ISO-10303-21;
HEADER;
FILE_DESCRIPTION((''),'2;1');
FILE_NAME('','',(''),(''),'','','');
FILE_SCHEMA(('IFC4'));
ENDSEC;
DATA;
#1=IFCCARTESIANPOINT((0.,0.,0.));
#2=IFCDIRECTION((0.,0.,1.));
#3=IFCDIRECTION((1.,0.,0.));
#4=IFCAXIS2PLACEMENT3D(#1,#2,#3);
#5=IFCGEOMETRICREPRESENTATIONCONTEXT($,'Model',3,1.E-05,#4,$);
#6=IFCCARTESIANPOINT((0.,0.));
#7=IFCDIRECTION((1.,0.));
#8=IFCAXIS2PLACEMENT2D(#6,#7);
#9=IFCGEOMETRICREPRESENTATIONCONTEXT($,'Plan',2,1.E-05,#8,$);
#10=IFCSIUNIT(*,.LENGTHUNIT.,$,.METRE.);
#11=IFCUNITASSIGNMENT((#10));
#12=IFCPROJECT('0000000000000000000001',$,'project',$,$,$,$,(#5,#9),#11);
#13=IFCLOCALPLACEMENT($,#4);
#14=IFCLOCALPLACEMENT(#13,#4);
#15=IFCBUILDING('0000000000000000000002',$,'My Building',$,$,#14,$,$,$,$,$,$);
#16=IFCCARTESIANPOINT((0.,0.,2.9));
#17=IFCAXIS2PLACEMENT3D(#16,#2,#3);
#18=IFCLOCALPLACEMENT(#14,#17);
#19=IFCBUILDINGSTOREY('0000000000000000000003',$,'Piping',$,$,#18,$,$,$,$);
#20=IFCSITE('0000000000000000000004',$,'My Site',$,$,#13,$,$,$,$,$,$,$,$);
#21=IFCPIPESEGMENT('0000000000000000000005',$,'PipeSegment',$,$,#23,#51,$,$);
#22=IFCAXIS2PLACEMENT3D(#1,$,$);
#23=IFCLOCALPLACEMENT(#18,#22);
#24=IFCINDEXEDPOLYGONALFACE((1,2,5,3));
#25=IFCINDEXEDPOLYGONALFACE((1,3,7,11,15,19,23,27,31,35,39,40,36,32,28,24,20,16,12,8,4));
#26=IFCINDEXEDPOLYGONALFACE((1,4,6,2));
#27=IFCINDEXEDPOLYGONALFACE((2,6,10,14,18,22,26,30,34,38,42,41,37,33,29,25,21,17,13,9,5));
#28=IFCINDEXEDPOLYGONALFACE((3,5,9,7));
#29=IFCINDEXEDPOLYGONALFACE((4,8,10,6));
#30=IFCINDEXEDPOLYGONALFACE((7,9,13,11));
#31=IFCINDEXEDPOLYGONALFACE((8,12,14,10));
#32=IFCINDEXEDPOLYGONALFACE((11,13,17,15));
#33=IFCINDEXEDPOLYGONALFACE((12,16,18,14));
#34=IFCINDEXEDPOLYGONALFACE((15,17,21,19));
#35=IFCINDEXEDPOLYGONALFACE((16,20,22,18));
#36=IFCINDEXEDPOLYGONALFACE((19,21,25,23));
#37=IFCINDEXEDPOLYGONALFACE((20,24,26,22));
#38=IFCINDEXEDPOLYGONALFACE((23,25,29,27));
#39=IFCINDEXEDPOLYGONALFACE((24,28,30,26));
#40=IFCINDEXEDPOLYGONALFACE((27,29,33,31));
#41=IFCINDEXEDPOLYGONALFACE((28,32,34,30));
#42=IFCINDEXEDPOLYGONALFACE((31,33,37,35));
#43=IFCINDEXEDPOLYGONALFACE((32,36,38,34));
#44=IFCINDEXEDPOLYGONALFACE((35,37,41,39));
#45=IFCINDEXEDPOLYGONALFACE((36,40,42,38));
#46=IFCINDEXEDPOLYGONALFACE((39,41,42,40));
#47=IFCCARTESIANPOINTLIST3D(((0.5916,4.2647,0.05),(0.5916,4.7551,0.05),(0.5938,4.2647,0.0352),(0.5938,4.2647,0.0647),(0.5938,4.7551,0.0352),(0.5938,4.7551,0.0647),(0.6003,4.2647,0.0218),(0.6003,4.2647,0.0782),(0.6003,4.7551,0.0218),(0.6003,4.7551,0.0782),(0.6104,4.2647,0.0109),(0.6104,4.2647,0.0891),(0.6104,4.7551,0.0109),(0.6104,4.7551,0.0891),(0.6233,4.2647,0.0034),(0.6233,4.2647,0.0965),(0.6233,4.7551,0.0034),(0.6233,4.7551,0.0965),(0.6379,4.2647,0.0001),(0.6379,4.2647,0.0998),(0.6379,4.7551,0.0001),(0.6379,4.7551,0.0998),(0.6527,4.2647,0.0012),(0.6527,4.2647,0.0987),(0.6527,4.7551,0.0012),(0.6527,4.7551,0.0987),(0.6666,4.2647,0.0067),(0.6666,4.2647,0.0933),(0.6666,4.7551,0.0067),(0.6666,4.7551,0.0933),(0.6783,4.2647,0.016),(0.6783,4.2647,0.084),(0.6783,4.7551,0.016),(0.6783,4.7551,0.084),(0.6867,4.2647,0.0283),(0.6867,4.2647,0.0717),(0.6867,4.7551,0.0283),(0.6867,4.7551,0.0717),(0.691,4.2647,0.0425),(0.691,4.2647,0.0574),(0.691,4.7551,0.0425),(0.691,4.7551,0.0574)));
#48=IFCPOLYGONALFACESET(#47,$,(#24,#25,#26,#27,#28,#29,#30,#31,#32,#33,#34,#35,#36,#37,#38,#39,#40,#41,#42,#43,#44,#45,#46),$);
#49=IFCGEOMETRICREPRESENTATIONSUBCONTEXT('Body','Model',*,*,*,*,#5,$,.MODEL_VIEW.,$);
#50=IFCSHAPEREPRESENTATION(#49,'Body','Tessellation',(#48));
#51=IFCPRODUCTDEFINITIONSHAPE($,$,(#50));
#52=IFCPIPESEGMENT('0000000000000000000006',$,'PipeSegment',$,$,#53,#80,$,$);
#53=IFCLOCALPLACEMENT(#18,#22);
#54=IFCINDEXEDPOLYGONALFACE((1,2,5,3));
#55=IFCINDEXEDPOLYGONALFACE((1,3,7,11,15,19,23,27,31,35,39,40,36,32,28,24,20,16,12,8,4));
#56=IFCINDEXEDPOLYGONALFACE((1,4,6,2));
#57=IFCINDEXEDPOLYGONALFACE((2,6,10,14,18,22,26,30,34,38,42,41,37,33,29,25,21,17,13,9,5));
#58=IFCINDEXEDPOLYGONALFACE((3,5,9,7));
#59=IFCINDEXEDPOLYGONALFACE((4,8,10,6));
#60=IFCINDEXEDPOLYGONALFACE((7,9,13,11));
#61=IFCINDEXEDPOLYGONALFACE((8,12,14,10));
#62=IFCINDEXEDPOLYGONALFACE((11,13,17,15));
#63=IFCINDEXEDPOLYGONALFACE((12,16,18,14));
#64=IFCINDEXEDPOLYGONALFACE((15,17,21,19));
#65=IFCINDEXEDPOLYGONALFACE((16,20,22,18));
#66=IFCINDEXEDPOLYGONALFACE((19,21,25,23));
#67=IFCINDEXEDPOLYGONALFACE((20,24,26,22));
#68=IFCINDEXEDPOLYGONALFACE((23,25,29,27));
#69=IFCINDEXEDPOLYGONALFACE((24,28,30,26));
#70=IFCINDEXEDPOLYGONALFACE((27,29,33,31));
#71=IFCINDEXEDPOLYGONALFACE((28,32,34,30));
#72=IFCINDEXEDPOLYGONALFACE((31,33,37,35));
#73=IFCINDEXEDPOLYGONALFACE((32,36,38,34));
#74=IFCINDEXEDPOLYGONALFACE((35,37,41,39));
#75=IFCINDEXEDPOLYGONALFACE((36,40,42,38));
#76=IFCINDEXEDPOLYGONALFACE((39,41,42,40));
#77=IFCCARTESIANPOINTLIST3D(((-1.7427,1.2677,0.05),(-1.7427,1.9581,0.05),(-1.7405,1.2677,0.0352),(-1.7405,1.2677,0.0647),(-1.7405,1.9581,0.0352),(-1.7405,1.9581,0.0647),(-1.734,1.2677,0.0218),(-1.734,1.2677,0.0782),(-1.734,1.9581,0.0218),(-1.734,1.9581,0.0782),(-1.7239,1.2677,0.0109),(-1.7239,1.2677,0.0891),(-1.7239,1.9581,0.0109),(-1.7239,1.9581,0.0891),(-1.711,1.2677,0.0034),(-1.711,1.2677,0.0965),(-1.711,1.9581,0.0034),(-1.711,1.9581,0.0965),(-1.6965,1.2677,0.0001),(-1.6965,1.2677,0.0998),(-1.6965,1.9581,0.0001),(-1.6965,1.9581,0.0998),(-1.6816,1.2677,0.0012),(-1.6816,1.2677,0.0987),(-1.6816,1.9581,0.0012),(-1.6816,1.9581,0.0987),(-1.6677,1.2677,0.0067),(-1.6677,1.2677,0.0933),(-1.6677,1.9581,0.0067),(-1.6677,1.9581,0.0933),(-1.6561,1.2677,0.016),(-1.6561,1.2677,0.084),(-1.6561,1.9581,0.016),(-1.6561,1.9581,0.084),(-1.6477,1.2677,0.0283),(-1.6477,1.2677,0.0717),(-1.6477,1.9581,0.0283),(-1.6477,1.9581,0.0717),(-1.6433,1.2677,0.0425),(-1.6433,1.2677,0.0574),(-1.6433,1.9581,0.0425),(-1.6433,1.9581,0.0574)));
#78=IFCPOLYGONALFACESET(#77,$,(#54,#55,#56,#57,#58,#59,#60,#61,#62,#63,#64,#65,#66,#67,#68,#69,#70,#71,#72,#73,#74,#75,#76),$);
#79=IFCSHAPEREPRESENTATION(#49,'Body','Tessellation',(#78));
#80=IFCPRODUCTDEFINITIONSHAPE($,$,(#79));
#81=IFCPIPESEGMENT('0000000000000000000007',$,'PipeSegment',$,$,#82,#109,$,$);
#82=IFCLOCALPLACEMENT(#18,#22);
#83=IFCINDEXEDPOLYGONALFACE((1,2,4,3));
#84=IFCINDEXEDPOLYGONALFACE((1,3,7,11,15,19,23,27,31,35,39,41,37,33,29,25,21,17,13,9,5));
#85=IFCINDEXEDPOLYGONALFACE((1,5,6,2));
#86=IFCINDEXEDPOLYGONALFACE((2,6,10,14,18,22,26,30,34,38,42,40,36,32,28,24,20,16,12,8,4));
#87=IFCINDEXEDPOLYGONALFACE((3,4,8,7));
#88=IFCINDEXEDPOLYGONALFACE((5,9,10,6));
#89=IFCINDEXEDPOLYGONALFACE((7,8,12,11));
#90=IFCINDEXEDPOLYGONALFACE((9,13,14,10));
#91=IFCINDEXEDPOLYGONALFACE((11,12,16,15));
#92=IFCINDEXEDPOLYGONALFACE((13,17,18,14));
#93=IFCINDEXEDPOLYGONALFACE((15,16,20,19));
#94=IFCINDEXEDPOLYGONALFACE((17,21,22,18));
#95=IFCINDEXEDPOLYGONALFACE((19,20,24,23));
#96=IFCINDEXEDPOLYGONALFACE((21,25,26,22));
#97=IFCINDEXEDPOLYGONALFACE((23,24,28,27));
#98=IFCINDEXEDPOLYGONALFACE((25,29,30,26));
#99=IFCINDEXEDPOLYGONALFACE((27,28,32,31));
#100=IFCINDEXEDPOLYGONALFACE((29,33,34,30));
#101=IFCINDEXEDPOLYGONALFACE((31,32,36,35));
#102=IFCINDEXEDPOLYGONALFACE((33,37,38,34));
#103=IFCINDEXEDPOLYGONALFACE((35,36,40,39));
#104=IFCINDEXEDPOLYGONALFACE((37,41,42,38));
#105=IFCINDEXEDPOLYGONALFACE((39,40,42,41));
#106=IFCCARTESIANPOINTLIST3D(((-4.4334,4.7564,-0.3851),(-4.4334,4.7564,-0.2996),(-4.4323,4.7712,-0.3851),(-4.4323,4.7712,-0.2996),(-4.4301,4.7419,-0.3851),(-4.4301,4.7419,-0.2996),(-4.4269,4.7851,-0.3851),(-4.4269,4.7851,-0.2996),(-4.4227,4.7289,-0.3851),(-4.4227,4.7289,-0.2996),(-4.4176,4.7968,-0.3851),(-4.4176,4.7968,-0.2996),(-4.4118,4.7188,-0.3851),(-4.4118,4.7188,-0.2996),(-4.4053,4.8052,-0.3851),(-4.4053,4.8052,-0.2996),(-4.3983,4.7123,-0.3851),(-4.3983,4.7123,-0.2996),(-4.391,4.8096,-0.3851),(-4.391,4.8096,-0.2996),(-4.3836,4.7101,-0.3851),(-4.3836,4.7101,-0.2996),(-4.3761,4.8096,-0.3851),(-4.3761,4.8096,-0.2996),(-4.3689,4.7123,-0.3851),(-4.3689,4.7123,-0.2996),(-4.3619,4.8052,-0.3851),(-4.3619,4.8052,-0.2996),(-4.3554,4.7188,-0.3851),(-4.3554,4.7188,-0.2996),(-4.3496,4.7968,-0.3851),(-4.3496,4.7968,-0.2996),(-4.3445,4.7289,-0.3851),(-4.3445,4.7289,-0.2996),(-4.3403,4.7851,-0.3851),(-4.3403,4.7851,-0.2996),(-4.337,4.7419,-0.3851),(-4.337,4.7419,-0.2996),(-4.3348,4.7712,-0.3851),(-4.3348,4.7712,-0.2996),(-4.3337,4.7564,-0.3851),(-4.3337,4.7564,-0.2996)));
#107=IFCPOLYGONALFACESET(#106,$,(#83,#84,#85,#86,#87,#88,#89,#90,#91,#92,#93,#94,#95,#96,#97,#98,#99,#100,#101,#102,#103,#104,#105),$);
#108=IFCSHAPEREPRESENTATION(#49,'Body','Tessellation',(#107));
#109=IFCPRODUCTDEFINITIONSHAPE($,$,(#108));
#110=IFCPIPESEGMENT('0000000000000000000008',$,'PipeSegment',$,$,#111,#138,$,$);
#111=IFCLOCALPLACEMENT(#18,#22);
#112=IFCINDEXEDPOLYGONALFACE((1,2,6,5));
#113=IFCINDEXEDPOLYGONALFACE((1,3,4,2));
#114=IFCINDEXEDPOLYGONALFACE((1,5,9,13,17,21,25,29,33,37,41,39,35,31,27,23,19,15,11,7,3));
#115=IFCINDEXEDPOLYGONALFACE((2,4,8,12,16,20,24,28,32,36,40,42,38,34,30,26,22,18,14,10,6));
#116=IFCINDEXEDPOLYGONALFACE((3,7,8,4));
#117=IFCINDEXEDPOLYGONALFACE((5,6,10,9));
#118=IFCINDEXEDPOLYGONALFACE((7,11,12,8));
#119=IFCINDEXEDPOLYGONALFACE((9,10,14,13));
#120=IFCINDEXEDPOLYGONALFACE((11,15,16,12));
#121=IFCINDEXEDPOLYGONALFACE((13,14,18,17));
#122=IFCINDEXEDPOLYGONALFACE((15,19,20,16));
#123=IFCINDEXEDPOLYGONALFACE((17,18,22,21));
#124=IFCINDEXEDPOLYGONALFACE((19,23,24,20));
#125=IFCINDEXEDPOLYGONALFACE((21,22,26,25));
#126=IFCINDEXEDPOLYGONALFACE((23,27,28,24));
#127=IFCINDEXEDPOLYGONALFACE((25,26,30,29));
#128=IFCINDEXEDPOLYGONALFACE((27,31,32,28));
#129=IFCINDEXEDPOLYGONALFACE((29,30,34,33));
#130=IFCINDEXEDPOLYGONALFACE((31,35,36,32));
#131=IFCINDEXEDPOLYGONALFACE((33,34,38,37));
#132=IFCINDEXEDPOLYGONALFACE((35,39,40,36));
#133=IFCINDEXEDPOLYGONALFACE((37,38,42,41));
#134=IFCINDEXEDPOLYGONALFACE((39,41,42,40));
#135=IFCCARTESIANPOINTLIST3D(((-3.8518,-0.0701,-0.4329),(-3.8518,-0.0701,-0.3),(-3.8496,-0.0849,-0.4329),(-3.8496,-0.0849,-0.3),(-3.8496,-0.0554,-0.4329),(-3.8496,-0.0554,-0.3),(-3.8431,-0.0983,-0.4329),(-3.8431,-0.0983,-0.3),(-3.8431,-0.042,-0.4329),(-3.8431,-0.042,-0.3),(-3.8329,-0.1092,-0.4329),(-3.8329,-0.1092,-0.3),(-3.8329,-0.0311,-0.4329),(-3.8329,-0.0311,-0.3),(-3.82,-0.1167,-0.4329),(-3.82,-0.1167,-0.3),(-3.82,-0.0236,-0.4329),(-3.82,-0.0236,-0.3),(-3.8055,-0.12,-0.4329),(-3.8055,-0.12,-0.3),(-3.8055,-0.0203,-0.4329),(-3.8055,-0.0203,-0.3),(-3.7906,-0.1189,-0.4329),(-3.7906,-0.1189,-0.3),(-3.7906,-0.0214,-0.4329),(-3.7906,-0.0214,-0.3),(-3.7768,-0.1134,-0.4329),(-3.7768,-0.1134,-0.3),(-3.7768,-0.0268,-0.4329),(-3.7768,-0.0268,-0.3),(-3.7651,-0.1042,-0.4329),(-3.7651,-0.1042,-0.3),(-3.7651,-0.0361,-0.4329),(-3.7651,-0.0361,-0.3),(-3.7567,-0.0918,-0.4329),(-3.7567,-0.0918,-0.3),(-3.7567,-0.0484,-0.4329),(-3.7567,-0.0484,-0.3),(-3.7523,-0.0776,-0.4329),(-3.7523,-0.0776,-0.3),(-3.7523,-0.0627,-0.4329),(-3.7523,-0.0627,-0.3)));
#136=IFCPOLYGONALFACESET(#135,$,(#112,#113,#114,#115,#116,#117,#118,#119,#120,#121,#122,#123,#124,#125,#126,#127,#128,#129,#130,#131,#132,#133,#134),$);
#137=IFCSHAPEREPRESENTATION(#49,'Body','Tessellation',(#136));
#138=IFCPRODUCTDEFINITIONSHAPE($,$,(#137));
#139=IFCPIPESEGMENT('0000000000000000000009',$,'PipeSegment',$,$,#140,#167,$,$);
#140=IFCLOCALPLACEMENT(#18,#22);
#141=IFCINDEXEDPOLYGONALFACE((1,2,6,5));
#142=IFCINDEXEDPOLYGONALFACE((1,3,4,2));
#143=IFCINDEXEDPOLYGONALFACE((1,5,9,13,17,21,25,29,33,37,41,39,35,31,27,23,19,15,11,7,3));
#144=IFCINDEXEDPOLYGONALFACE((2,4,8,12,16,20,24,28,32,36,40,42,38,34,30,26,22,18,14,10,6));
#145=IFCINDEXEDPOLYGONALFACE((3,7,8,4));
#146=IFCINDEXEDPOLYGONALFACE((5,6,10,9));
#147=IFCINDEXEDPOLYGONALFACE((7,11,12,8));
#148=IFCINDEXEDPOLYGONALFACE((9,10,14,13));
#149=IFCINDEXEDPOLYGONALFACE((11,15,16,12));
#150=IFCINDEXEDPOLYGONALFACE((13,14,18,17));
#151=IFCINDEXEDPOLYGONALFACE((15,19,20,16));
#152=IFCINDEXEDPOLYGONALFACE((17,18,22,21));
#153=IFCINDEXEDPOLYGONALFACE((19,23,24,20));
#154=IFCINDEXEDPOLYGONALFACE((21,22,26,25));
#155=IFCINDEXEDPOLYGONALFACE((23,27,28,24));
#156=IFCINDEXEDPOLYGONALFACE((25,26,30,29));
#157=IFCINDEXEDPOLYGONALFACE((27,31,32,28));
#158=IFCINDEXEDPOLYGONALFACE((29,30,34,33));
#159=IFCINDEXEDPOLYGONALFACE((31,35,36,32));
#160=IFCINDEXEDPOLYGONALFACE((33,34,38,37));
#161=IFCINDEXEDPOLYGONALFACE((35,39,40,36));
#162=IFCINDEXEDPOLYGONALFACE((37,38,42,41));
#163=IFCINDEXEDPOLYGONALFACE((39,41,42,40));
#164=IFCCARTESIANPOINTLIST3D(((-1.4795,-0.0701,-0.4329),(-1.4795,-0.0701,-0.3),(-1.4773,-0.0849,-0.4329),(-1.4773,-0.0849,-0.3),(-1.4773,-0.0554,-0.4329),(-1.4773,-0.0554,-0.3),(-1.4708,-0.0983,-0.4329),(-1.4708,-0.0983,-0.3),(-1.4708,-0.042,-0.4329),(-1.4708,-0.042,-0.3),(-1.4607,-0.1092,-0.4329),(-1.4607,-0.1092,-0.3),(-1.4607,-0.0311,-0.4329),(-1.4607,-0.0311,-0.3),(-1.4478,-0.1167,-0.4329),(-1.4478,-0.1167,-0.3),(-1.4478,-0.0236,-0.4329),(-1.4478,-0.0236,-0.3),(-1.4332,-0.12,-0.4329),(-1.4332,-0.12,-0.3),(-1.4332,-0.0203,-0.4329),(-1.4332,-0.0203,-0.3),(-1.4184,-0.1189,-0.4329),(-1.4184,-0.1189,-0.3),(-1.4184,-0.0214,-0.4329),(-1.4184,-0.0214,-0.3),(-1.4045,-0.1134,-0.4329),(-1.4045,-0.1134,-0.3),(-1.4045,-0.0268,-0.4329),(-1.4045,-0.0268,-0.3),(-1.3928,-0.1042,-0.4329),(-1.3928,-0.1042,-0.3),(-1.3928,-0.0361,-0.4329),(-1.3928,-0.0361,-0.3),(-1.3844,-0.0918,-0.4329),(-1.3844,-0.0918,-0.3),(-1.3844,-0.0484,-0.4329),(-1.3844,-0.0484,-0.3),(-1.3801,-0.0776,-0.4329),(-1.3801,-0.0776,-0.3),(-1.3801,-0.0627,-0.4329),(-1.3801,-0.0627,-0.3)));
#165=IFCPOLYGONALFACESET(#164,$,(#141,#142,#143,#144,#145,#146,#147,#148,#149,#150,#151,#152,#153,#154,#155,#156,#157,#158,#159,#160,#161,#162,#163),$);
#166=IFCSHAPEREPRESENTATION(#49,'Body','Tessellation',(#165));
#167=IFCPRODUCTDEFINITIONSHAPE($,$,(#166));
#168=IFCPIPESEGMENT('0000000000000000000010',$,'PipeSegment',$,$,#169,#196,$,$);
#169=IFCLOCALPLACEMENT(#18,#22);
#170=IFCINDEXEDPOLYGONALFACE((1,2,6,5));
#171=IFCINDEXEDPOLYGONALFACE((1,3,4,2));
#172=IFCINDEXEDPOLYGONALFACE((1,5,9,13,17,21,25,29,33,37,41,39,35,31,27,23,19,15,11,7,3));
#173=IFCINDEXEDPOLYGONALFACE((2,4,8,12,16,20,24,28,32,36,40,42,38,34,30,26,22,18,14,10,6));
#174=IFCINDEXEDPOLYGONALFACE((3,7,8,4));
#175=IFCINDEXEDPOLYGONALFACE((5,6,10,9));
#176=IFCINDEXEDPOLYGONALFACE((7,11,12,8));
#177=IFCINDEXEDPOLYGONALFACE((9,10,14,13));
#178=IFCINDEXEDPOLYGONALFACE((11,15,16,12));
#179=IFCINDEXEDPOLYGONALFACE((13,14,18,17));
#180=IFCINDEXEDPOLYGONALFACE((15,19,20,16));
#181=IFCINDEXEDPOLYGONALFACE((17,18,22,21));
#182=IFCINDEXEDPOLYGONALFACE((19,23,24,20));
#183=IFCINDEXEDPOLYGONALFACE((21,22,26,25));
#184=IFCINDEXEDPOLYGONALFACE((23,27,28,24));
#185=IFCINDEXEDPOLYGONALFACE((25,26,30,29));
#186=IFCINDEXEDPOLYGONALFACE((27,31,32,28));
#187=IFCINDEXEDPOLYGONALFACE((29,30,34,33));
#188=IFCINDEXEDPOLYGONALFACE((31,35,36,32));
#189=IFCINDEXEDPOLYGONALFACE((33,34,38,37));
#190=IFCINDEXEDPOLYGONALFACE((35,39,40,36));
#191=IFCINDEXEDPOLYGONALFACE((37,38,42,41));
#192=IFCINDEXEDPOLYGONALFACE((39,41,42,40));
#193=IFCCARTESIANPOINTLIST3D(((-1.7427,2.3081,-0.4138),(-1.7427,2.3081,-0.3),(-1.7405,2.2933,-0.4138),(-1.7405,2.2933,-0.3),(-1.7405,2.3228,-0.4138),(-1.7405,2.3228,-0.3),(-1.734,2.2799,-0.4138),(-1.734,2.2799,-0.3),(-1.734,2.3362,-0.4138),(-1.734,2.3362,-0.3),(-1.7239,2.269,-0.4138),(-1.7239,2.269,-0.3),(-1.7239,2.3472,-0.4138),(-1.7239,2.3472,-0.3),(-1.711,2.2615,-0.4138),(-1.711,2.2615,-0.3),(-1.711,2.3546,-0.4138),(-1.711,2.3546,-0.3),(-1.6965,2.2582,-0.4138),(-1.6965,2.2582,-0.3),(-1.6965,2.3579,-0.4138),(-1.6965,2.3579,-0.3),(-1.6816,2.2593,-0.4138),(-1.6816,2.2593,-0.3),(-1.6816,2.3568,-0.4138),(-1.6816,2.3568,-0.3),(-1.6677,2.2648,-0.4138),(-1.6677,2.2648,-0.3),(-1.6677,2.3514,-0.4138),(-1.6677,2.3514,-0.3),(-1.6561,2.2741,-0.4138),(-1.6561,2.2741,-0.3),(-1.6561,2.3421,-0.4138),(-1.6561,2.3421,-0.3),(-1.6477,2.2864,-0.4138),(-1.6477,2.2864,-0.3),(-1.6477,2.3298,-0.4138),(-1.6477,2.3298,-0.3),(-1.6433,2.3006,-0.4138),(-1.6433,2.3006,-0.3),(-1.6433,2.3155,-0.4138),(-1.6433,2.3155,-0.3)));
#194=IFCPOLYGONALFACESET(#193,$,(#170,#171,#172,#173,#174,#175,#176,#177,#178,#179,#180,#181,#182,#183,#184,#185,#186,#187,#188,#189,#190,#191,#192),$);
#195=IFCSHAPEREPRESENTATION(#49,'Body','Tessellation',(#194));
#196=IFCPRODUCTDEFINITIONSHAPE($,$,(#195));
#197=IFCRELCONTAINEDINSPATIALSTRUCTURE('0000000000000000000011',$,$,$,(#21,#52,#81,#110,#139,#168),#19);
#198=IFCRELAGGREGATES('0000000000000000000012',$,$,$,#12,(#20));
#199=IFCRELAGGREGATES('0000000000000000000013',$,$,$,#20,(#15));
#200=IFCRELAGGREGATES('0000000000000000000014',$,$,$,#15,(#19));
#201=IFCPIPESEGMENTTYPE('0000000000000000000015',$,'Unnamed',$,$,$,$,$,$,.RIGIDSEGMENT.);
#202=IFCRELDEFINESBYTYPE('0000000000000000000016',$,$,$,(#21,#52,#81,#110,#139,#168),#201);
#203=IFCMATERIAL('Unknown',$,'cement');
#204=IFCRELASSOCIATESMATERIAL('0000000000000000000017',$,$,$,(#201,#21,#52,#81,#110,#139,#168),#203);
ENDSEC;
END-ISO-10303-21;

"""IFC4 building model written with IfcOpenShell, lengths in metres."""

from ifc_helpers import new_model, si_unit, frame, origin_with_axes, origin_2d_with_axis, place, context, subcontext, project, spatial, circle, extrude, material, material_profile, profile_set, profile_usage, type_object, element, save


model = new_model("IFC4")

# Units and contexts
model_context = context("Model", 3, precision=1e-05, world=origin_with_axes())
plan_context = context("Plan", 2, precision=1e-05, world=origin_2d_with_axis())
body_context = subcontext(model_context, "Body", "Model", "MODEL_VIEW")
ifc_project = project(units=[si_unit("LENGTHUNIT", "METRE")], contexts=[model_context, plan_context])

# Site, building, storey
site_placement = place(None, origin_with_axes())
site = spatial("IfcSite", under=ifc_project, at=site_placement, Name="My Site")
building_placement = place(site_placement, origin_with_axes())
building = spatial("IfcBuilding", under=site, at=building_placement, Name="My Building")
storey_placement = place(building_placement, frame((0.0, 0.0, 2.9), z_axis=(0.0, 0.0, 1.0), x_axis=(1.0, 0.0, 0.0)))
storey = spatial("IfcBuildingStorey", under=building, at=storey_placement, Name="Piping")

# Pipe segments
ifc_material = material(Name="Unknown", Category="cement")
ifc_material_profile_1 = material_profile(ifc_material, circle(Radius=0.05))
ifc_profile_set_1 = profile_set([ifc_material_profile_1])
pipe_segment_type = type_object("IfcPipeSegmentType", Name="Unnamed", PredefinedType="RIGIDSEGMENT", material=ifc_profile_set_1)
ifc_profile_usage_1 = profile_usage(ifc_profile_set_1, cardinal=5)
pipe_segment_1_placement = place(storey_placement, frame((0.6416, 4.2647, 0.05), z_axis=(0.0, 1.0, 0.0), x_axis=(-1.0, 0.0, 0.0)))
element("IfcPipeSegment", 1, at=pipe_segment_1_placement, inside=storey, type_object=pipe_segment_type, material=ifc_profile_usage_1, Name="PipeSegment", context=body_context, shape_type="SweptSolid", body=[
    extrude(circle(Radius=0.05), origin_with_axes(), (0.0, 0.0, 1.0), 0.4905),
])
ifc_profile_usage_2 = profile_usage(ifc_profile_set_1, cardinal=5)
pipe_segment_2_placement = place(storey_placement, frame((-1.6927, 1.2677, 0.05), z_axis=(0.0, 1.0, 0.0), x_axis=(-1.0, 0.0, 0.0)))
element("IfcPipeSegment", 2, at=pipe_segment_2_placement, inside=storey, type_object=pipe_segment_type, material=ifc_profile_usage_2, Name="PipeSegment", context=body_context, shape_type="SweptSolid", body=[
    extrude(circle(Radius=0.05), origin_with_axes(), (0.0, 0.0, 1.0), 0.6904),
])
ifc_profile_usage_3 = profile_usage(ifc_profile_set_1, cardinal=5)
pipe_segment_3_placement = place(storey_placement, frame((-4.3836, 4.7601, -0.3851), z_axis=(0.0, 0.0, 1.0), x_axis=(0.0, -1.0, 0.0)))
element("IfcPipeSegment", 3, at=pipe_segment_3_placement, inside=storey, type_object=pipe_segment_type, material=ifc_profile_usage_3, Name="PipeSegment", context=body_context, shape_type="SweptSolid", body=[
    extrude(circle(Radius=0.05), origin_with_axes(), (0.0, 0.0, 1.0), 0.0855),
])
ifc_profile_usage_4 = profile_usage(ifc_profile_set_1, cardinal=5)
pipe_segment_4_placement = place(storey_placement, frame((-3.8018, -0.0701, -0.4329), z_axis=(0.0, 0.0, 1.0), x_axis=(-1.0, 0.0, 0.0)))
element("IfcPipeSegment", 4, at=pipe_segment_4_placement, inside=storey, type_object=pipe_segment_type, material=ifc_profile_usage_4, Name="PipeSegment", context=body_context, shape_type="SweptSolid", body=[
    extrude(circle(Radius=0.05), origin_with_axes(), (0.0, 0.0, 1.0), 0.1329),
])
ifc_profile_usage_5 = profile_usage(ifc_profile_set_1, cardinal=5)
pipe_segment_5_placement = place(storey_placement, frame((-1.4295, -0.0701, -0.4329), z_axis=(0.0, 0.0, 1.0), x_axis=(-1.0, 0.0, 0.0)))
element("IfcPipeSegment", 5, at=pipe_segment_5_placement, inside=storey, type_object=pipe_segment_type, material=ifc_profile_usage_5, Name="PipeSegment", context=body_context, shape_type="SweptSolid", body=[
    extrude(circle(Radius=0.05), origin_with_axes(), (0.0, 0.0, 1.0), 0.1329),
])
ifc_profile_usage_6 = profile_usage(ifc_profile_set_1, cardinal=5)
pipe_segment_6_placement = place(storey_placement, frame((-1.6927, 2.3081, -0.4138), z_axis=(0.0, 0.0, 1.0), x_axis=(-1.0, 0.0, 0.0)))
element("IfcPipeSegment", 6, at=pipe_segment_6_placement, inside=storey, type_object=pipe_segment_type, material=ifc_profile_usage_6, Name="PipeSegment", context=body_context, shape_type="SweptSolid", body=[
    extrude(circle(Radius=0.05), origin_with_axes(), (0.0, 0.0, 1.0), 0.1138),
])

save(model, "model.ifc")
